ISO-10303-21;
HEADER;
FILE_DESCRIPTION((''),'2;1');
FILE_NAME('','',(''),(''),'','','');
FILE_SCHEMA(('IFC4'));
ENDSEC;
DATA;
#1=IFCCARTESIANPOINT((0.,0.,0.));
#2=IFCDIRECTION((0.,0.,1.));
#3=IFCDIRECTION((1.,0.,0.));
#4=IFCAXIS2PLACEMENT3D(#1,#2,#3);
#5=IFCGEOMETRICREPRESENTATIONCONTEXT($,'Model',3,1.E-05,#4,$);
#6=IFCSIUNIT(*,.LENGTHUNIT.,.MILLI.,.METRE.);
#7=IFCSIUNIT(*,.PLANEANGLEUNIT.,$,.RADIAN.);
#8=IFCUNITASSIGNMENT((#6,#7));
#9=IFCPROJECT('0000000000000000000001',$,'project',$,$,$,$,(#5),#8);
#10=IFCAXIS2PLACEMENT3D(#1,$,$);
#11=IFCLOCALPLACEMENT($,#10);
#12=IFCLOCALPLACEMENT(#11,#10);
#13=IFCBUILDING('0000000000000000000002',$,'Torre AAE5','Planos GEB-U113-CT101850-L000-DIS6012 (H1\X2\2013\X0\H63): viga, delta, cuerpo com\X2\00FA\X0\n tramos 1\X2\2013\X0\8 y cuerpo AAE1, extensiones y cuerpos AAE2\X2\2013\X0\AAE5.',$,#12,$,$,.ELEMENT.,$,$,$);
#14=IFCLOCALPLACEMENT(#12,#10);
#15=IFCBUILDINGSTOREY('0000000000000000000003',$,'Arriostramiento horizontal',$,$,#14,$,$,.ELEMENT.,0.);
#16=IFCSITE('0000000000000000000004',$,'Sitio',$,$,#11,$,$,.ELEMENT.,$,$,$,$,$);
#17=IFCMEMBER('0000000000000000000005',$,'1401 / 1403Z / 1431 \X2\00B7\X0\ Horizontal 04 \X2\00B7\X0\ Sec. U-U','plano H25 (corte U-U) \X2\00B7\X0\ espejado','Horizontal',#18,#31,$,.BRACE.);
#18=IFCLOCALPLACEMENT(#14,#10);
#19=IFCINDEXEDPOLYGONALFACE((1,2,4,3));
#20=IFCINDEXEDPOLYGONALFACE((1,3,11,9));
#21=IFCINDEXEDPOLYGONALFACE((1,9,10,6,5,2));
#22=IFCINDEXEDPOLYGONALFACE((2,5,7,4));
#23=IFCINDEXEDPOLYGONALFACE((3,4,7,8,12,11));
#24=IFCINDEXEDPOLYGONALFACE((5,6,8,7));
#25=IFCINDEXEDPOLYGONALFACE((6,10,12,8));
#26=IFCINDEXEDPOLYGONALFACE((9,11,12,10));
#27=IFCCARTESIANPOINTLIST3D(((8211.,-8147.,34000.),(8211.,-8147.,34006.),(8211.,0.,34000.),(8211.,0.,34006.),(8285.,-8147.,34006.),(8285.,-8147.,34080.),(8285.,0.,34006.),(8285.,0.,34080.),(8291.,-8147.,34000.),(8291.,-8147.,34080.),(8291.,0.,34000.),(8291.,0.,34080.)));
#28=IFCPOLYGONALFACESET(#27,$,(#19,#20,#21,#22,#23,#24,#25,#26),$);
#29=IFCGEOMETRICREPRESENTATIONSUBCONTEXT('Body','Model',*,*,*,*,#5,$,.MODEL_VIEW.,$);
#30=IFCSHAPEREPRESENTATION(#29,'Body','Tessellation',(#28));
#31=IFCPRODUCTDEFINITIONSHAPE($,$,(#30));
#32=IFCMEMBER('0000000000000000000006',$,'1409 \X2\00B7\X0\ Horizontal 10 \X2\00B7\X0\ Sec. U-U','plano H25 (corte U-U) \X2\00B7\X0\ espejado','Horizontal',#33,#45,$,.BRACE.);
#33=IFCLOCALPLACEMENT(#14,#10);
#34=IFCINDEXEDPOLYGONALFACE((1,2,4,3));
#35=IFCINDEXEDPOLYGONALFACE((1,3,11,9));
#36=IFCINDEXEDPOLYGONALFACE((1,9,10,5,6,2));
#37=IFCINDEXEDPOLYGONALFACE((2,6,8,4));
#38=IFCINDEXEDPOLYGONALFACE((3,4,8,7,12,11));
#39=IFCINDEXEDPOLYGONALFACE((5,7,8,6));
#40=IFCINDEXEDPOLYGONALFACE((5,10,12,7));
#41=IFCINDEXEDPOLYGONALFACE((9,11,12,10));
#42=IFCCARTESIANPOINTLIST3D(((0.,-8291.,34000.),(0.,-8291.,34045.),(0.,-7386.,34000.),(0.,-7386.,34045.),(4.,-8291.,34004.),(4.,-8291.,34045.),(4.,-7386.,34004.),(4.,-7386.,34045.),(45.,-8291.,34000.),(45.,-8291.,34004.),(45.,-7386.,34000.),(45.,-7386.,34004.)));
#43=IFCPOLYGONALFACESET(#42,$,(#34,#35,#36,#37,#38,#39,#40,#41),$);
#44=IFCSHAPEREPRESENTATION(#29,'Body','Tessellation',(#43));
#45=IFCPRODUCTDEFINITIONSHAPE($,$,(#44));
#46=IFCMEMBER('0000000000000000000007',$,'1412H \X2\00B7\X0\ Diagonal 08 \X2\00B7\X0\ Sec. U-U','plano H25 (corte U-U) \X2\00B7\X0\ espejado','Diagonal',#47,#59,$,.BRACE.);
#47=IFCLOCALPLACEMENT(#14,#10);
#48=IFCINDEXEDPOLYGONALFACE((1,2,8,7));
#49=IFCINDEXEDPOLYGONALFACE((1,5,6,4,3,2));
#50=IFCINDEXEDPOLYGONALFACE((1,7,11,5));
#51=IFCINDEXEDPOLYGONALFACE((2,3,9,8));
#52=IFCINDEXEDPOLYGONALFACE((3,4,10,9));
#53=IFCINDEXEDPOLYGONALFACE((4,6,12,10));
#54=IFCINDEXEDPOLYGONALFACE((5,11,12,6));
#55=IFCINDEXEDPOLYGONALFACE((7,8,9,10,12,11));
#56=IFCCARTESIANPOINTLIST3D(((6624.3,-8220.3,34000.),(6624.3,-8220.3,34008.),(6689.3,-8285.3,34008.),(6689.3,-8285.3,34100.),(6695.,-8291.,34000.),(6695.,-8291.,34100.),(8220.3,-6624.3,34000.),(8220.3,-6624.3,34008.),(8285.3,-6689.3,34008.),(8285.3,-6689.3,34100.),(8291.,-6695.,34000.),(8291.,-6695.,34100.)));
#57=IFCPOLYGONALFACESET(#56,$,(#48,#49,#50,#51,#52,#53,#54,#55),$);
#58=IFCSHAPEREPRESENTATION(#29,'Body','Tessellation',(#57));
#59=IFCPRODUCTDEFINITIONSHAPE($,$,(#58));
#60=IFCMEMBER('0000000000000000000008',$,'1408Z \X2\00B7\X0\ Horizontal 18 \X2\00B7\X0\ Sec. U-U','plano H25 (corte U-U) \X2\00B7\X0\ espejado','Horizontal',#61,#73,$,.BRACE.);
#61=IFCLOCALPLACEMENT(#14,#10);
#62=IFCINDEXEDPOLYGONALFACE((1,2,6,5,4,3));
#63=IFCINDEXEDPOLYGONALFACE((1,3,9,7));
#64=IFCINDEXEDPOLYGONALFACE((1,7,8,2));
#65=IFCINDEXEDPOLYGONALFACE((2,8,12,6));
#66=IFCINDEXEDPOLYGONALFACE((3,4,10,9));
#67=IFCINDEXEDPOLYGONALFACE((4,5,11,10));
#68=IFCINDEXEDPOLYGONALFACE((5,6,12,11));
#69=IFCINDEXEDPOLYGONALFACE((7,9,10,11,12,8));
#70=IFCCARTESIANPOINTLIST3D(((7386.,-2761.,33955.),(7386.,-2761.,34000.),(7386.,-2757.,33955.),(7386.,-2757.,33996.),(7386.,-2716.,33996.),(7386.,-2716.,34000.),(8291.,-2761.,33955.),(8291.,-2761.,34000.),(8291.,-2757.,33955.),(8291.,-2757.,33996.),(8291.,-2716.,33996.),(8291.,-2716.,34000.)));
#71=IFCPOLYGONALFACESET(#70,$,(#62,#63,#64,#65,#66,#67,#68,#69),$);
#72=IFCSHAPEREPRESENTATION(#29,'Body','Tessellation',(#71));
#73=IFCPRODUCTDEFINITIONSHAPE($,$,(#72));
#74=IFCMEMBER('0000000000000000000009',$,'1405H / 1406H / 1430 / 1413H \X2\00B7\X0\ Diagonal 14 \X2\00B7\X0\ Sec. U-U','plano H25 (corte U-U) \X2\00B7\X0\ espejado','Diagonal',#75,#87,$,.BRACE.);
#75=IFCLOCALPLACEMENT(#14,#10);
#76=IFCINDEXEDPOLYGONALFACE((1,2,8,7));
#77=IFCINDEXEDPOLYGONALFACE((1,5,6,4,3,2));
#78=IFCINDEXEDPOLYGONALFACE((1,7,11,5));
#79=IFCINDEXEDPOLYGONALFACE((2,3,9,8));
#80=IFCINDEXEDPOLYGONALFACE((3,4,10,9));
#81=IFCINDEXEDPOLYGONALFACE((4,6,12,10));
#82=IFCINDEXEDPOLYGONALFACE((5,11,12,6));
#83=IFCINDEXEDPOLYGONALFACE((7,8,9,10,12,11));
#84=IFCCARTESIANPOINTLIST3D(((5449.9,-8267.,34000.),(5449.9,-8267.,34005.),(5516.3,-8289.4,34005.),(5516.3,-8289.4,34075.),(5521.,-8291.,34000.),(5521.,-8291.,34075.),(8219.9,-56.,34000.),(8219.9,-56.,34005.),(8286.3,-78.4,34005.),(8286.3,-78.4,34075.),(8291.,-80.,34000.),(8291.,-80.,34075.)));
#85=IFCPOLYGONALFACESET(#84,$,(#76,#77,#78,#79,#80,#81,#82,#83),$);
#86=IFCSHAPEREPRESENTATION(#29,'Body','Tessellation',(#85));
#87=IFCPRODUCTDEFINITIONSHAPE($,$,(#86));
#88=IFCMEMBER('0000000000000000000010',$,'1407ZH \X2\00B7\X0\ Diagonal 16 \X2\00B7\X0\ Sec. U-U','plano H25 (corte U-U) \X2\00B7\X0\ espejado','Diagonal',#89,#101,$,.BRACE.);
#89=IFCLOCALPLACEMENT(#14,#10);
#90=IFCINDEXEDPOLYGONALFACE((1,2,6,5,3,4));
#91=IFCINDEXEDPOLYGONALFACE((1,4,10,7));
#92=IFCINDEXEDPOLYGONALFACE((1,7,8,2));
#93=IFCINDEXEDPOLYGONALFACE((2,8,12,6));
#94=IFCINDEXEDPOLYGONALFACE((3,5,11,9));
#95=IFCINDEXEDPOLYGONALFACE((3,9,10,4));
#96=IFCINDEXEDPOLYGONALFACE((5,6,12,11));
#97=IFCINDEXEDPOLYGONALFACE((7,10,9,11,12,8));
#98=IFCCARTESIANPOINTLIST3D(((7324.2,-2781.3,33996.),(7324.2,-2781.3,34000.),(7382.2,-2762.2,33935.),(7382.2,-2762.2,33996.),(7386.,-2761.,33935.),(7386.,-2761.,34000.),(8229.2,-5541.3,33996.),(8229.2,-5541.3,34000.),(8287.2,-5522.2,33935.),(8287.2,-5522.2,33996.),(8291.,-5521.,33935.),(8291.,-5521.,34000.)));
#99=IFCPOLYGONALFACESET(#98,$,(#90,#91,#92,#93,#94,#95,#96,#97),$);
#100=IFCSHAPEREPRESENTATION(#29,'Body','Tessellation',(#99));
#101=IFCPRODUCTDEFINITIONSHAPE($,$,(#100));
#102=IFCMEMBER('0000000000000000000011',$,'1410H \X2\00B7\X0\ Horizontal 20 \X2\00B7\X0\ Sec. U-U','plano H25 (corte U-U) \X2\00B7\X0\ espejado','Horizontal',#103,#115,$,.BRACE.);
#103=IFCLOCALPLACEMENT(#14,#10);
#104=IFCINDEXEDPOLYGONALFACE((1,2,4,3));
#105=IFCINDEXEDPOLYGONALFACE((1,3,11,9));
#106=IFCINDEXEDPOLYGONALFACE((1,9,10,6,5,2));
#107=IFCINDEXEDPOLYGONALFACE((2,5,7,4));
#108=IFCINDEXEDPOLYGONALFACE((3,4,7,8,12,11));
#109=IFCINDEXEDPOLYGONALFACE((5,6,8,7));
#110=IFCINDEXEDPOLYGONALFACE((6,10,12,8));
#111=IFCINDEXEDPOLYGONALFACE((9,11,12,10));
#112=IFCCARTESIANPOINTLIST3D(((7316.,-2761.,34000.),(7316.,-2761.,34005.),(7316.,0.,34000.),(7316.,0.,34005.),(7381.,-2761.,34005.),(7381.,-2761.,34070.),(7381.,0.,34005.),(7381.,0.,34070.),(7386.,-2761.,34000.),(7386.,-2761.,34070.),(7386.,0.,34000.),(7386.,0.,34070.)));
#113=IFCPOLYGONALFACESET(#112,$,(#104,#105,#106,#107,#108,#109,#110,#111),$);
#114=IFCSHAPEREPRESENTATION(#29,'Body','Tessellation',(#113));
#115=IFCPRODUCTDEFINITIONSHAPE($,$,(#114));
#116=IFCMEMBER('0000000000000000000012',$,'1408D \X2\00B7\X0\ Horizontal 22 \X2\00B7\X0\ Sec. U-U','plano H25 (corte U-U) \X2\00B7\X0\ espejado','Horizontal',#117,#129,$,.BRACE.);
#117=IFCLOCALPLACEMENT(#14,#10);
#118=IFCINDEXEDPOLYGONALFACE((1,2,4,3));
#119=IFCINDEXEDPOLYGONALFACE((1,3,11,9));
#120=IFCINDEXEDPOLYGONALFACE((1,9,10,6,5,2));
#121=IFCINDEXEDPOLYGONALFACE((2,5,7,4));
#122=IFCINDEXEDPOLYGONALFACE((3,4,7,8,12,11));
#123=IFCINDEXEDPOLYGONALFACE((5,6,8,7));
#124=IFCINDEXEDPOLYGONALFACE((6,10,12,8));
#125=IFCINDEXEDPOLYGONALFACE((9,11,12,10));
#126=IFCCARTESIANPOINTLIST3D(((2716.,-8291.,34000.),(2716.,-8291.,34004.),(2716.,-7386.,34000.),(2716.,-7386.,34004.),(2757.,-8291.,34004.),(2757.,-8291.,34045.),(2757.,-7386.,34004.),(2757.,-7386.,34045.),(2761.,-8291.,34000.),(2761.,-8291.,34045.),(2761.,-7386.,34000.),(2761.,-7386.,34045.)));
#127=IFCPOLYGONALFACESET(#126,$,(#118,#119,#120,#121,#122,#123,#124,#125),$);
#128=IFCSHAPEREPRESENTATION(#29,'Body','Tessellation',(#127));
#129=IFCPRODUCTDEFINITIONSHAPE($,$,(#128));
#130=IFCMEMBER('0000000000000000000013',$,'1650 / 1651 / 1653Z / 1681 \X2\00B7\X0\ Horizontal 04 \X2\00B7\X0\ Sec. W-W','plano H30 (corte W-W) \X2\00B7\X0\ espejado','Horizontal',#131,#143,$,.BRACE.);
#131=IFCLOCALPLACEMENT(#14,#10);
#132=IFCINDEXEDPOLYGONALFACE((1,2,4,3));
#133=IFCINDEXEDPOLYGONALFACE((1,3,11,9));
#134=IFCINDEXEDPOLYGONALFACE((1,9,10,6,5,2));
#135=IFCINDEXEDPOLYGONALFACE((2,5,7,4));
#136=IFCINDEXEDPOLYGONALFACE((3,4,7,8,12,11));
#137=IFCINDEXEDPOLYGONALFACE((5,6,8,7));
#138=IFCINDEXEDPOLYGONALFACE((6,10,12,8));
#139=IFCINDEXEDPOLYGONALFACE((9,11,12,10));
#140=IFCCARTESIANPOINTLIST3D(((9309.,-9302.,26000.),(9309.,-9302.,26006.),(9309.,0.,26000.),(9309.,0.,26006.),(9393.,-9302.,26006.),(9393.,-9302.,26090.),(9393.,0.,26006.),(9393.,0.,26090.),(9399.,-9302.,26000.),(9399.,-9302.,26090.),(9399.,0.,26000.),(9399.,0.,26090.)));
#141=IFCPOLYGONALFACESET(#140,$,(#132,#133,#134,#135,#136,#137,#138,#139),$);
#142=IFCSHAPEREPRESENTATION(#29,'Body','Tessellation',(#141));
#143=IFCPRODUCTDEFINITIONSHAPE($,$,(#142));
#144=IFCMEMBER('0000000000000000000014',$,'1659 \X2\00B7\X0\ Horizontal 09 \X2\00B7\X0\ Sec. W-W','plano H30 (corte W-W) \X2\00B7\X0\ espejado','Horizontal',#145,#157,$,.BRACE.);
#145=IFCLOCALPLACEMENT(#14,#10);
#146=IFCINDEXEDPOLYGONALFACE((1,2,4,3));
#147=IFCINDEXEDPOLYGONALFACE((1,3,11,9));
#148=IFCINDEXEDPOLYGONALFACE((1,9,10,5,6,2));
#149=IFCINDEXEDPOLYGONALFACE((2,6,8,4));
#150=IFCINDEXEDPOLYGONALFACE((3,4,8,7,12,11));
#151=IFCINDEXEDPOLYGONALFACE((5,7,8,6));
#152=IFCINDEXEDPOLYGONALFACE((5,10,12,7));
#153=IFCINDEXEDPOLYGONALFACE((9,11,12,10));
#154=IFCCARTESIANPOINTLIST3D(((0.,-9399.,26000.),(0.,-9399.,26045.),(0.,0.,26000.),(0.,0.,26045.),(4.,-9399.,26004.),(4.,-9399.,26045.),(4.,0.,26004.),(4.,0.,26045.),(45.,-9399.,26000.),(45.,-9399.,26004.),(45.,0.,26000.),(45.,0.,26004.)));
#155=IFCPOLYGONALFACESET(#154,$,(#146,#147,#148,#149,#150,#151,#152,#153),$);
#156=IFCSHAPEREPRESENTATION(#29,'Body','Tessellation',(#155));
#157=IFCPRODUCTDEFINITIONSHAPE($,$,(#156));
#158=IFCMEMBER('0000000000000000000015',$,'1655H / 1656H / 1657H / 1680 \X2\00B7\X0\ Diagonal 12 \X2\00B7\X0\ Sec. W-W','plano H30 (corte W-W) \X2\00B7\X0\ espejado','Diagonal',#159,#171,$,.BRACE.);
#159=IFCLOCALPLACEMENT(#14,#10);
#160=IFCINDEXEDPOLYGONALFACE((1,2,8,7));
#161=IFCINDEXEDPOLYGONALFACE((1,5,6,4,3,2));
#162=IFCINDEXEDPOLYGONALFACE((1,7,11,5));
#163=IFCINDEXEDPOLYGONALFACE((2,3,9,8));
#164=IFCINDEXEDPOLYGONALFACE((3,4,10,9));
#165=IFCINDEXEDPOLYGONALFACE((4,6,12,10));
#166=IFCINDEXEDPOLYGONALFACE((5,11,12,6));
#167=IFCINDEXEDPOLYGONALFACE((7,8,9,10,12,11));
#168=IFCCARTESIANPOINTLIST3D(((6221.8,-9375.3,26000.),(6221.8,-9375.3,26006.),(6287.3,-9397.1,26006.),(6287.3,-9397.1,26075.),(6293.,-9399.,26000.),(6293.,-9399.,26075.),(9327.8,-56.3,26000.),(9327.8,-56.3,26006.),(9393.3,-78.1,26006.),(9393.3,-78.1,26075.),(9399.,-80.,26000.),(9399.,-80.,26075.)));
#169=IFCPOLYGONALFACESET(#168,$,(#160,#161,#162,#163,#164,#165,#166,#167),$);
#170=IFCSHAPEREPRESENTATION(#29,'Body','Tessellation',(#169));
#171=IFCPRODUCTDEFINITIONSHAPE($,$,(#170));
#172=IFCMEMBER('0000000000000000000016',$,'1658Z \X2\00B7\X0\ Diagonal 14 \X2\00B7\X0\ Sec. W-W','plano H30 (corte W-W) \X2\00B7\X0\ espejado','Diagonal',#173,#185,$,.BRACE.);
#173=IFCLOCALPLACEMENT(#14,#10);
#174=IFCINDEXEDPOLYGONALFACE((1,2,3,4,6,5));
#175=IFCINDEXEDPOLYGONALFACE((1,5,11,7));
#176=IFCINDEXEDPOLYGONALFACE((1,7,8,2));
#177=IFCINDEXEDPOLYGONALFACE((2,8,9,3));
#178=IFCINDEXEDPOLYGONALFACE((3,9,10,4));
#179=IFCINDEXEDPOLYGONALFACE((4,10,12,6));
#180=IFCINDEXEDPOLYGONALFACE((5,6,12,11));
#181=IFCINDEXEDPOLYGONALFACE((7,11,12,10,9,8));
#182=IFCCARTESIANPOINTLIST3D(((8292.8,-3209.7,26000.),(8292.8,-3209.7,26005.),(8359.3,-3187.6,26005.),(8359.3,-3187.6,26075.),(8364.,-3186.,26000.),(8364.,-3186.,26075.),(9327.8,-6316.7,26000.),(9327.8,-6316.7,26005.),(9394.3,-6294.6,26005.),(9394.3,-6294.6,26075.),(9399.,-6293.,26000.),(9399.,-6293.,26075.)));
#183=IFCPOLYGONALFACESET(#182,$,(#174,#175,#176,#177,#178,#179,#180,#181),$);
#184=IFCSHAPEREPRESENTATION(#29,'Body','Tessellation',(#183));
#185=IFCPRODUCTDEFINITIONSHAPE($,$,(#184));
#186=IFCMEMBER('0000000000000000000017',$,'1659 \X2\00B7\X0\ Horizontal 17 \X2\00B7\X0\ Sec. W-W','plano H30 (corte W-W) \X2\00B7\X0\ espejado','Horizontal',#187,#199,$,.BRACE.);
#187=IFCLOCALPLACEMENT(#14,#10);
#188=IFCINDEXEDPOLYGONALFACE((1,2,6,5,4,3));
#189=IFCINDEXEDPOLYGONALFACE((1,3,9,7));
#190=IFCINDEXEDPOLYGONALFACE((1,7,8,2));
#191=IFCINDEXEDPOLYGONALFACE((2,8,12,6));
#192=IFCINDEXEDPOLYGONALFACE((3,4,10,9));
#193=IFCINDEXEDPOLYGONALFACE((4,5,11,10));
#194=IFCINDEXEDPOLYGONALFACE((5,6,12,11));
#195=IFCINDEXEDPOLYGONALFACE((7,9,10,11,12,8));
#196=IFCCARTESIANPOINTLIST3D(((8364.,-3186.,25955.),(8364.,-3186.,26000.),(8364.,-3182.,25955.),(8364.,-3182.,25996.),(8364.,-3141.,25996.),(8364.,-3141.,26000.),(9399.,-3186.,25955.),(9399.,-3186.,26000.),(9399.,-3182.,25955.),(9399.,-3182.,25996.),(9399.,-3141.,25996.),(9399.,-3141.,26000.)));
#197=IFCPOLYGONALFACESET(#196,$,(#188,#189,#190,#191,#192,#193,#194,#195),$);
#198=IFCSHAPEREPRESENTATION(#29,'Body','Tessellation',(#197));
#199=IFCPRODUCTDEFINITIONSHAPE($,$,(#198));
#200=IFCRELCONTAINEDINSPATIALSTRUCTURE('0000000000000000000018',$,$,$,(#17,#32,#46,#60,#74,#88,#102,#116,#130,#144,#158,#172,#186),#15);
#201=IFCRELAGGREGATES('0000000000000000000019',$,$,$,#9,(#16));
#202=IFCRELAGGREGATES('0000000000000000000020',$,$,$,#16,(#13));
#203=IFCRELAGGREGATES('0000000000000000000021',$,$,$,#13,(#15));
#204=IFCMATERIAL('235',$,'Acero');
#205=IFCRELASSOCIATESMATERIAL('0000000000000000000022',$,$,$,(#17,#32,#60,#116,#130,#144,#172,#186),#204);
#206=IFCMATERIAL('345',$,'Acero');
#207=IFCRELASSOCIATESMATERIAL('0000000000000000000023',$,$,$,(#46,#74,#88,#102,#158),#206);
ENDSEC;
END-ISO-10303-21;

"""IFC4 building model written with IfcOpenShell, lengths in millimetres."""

from ifc_helpers import new_model, si_unit, frame, frame_2d, origin, origin_with_axes, place, context, subcontext, project, spatial, l_section, extrude, material, element, save


model = new_model("IFC4")

# Units and contexts
model_context = context("Model", 3, precision=1e-05, world=origin_with_axes())
body_context = subcontext(model_context, "Body", "Model", "MODEL_VIEW")
ifc_project = project(units=[si_unit("LENGTHUNIT", "METRE", prefix="MILLI"), si_unit("PLANEANGLEUNIT", "RADIAN")], contexts=[model_context])

# Site, building, storey
site_placement = place(None, origin())
site = spatial("IfcSite", under=ifc_project, at=site_placement, Name="Sitio", CompositionType="ELEMENT")
building_placement = place(site_placement, origin())
building = spatial("IfcBuilding", under=site, at=building_placement, Name="Torre AAE5", Description="Planos GEB-U113-CT101850-L000-DIS6012 (H1–H63): viga, delta, cuerpo común tramos 1–8 y cuerpo AAE1, extensiones y cuerpos AAE2–AAE5.", CompositionType="ELEMENT")
storey_placement = place(building_placement, origin())
storey = spatial("IfcBuildingStorey", under=building, at=storey_placement, Name="Arriostramiento horizontal", CompositionType="ELEMENT", Elevation=0.0)

# Members
ifc_material_1 = material(Name="235", Category="Acero")
member_1_placement = place(storey_placement, frame((8291.0, -8147.0, 34000.0), z_axis=(0.0, 1.0, 0.0), x_axis=(-1.0, 0.0, 0.0)))
element("IfcMember", 1, at=member_1_placement, inside=storey, material=ifc_material_1, Name="1401 / 1403Z / 1431 · Horizontal 04 · Sec. U-U", Description="plano H25 (corte U-U) · espejado", ObjectType="Horizontal", PredefinedType="BRACE", context=body_context, shape_type="SweptSolid", body=[
    extrude(l_section(Depth=80.0, Width=80.0, Thickness=6.0, at=frame_2d((40.0, 40.0))), None, (0.0, 0.0, 1.0), 8147.0),
])
member_2_placement = place(storey_placement, frame((0.0, -8291.0, 34000.0), z_axis=(0.0, 1.0, 0.0), x_axis=(0.0, 0.0, 1.0)))
element("IfcMember", 2, at=member_2_placement, inside=storey, material=ifc_material_1, Name="1409 · Horizontal 10 · Sec. U-U", Description="plano H25 (corte U-U) · espejado", ObjectType="Horizontal", PredefinedType="BRACE", context=body_context, shape_type="SweptSolid", body=[
    extrude(l_section(Depth=45.0, Width=45.0, Thickness=4.0, at=frame_2d((22.5, 22.5))), None, (0.0, 0.0, 1.0), 905.0),
])
ifc_material_2 = material(Name="345", Category="Acero")
member_3_placement = place(storey_placement, frame((6695.0, -8291.0, 34000.0), z_axis=(0.707107, 0.707107, 0.0), x_axis=(-0.707107, 0.707107, 0.0)))
element("IfcMember", 3, at=member_3_placement, inside=storey, material=ifc_material_2, Name="1412H · Diagonal 08 · Sec. U-U", Description="plano H25 (corte U-U) · espejado", ObjectType="Diagonal", PredefinedType="BRACE", context=body_context, shape_type="SweptSolid", body=[
    extrude(l_section(Depth=100.0, Width=100.0, Thickness=8.0, at=frame_2d((50.0, 50.0))), None, (0.0, 0.0, 1.0), 2257.1),
])
member_4_placement = place(storey_placement, frame((8291.0, -2761.0, 34000.0), z_axis=(-1.0, 0.0, 0.0), x_axis=(0.0, 1.0, 0.0)))
element("IfcMember", 4, at=member_4_placement, inside=storey, material=ifc_material_1, Name="1408Z · Horizontal 18 · Sec. U-U", Description="plano H25 (corte U-U) · espejado", ObjectType="Horizontal", PredefinedType="BRACE", context=body_context, shape_type="SweptSolid", body=[
    extrude(l_section(Depth=45.0, Width=45.0, Thickness=4.0, at=frame_2d((22.5, 22.5))), None, (0.0, 0.0, 1.0), 905.0),
])
member_5_placement = place(storey_placement, frame((5521.0, -8291.0, 34000.0), z_axis=(0.319653, 0.947535, 0.0), x_axis=(-0.947535, 0.319653, 0.0)))
element("IfcMember", 5, at=member_5_placement, inside=storey, material=ifc_material_2, Name="1405H / 1406H / 1430 / 1413H · Diagonal 14 · Sec. U-U", Description="plano H25 (corte U-U) · espejado", ObjectType="Diagonal", PredefinedType="BRACE", context=body_context, shape_type="SweptSolid", body=[
    extrude(l_section(Depth=75.0, Width=75.0, Thickness=5.0, at=frame_2d((37.5, 37.5))), None, (0.0, 0.0, 1.0), 8665.6),
])
member_6_placement = place(storey_placement, frame((7386.0, -2761.0, 34000.0), z_axis=(0.311576, -0.950221, 0.0), x_axis=(-0.950221, -0.311576, 0.0)))
element("IfcMember", 6, at=member_6_placement, inside=storey, material=ifc_material_2, Name="1407ZH · Diagonal 16 · Sec. U-U", Description="plano H25 (corte U-U) · espejado", ObjectType="Diagonal", PredefinedType="BRACE", context=body_context, shape_type="SweptSolid", body=[
    extrude(l_section(Depth=65.0, Width=65.0, Thickness=4.0, at=frame_2d((32.5, 32.5))), None, (0.0, 0.0, 1.0), 2904.6),
])
member_7_placement = place(storey_placement, frame((7386.0, -2761.0, 34000.0), z_axis=(0.0, 1.0, 0.0), x_axis=(-1.0, 0.0, 0.0)))
element("IfcMember", 7, at=member_7_placement, inside=storey, material=ifc_material_2, Name="1410H · Horizontal 20 · Sec. U-U", Description="plano H25 (corte U-U) · espejado", ObjectType="Horizontal", PredefinedType="BRACE", context=body_context, shape_type="SweptSolid", body=[
    extrude(l_section(Depth=70.0, Width=70.0, Thickness=5.0, at=frame_2d((35.0, 35.0))), None, (0.0, 0.0, 1.0), 2761.0),
])
member_8_placement = place(storey_placement, frame((2761.0, -8291.0, 34000.0), z_axis=(0.0, 1.0, 0.0), x_axis=(-1.0, 0.0, 0.0)))
element("IfcMember", 8, at=member_8_placement, inside=storey, material=ifc_material_1, Name="1408D · Horizontal 22 · Sec. U-U", Description="plano H25 (corte U-U) · espejado", ObjectType="Horizontal", PredefinedType="BRACE", context=body_context, shape_type="SweptSolid", body=[
    extrude(l_section(Depth=45.0, Width=45.0, Thickness=4.0, at=frame_2d((22.5, 22.5))), None, (0.0, 0.0, 1.0), 905.0),
])
member_9_placement = place(storey_placement, frame((9399.0, -9302.0, 26000.0), z_axis=(0.0, 1.0, 0.0), x_axis=(-1.0, 0.0, 0.0)))
element("IfcMember", 9, at=member_9_placement, inside=storey, material=ifc_material_1, Name="1650 / 1651 / 1653Z / 1681 · Horizontal 04 · Sec. W-W", Description="plano H30 (corte W-W) · espejado", ObjectType="Horizontal", PredefinedType="BRACE", context=body_context, shape_type="SweptSolid", body=[
    extrude(l_section(Depth=90.0, Width=90.0, Thickness=6.0, at=frame_2d((45.0, 45.0))), None, (0.0, 0.0, 1.0), 9302.0),
])
member_10_placement = place(storey_placement, frame((0.0, -9399.0, 26000.0), z_axis=(0.0, 1.0, 0.0), x_axis=(0.0, 0.0, 1.0)))
element("IfcMember", 10, at=member_10_placement, inside=storey, material=ifc_material_1, Name="1659 · Horizontal 09 · Sec. W-W", Description="plano H30 (corte W-W) · espejado", ObjectType="Horizontal", PredefinedType="BRACE", context=body_context, shape_type="SweptSolid", body=[
    extrude(l_section(Depth=45.0, Width=45.0, Thickness=4.0, at=frame_2d((22.5, 22.5))), None, (0.0, 0.0, 1.0), 9399.0),
])
member_11_placement = place(storey_placement, frame((6293.0, -9399.0, 26000.0), z_axis=(0.316197, 0.948693, 0.0), x_axis=(-0.948693, 0.316197, 0.0)))
element("IfcMember", 11, at=member_11_placement, inside=storey, material=ifc_material_2, Name="1655H / 1656H / 1657H / 1680 · Diagonal 12 · Sec. W-W", Description="plano H30 (corte W-W) · espejado", ObjectType="Diagonal", PredefinedType="BRACE", context=body_context, shape_type="SweptSolid", body=[
    extrude(l_section(Depth=75.0, Width=75.0, Thickness=6.0, at=frame_2d((37.5, 37.5))), None, (0.0, 0.0, 1.0), 9823.0),
])
member_12_placement = place(storey_placement, frame((9399.0, -6293.0, 26000.0), z_axis=(-0.316045, 0.948744, 0.0), x_axis=(-0.948744, -0.316045, 0.0)))
element("IfcMember", 12, at=member_12_placement, inside=storey, material=ifc_material_1, Name="1658Z · Diagonal 14 · Sec. W-W", Description="plano H30 (corte W-W) · espejado", ObjectType="Diagonal", PredefinedType="BRACE", context=body_context, shape_type="SweptSolid", body=[
    extrude(l_section(Depth=75.0, Width=75.0, Thickness=5.0, at=frame_2d((37.5, 37.5))), None, (0.0, 0.0, 1.0), 3274.9),
])
for number, where, z_axis, x_axis, name in (
    (13, (9399.0, -3186.0, 26000.0), (-1.0, 0.0, 0.0), (0.0, 1.0, 0.0), "1659 · Horizontal 17 · Sec. W-W"),
):
    element("IfcMember", number, at=place(storey_placement, frame(where, z_axis=z_axis, x_axis=x_axis)), inside=storey, material=ifc_material_1, Name=name, Description="plano H30 (corte W-W) · espejado", ObjectType="Horizontal", PredefinedType="BRACE", context=body_context, shape_type="SweptSolid", body=[
        extrude(l_section(Depth=45.0, Width=45.0, Thickness=4.0, at=frame_2d((22.5, 22.5))), None, (0.0, 0.0, 1.0), 1035.0),
    ])

save(model, "model.ifc")
